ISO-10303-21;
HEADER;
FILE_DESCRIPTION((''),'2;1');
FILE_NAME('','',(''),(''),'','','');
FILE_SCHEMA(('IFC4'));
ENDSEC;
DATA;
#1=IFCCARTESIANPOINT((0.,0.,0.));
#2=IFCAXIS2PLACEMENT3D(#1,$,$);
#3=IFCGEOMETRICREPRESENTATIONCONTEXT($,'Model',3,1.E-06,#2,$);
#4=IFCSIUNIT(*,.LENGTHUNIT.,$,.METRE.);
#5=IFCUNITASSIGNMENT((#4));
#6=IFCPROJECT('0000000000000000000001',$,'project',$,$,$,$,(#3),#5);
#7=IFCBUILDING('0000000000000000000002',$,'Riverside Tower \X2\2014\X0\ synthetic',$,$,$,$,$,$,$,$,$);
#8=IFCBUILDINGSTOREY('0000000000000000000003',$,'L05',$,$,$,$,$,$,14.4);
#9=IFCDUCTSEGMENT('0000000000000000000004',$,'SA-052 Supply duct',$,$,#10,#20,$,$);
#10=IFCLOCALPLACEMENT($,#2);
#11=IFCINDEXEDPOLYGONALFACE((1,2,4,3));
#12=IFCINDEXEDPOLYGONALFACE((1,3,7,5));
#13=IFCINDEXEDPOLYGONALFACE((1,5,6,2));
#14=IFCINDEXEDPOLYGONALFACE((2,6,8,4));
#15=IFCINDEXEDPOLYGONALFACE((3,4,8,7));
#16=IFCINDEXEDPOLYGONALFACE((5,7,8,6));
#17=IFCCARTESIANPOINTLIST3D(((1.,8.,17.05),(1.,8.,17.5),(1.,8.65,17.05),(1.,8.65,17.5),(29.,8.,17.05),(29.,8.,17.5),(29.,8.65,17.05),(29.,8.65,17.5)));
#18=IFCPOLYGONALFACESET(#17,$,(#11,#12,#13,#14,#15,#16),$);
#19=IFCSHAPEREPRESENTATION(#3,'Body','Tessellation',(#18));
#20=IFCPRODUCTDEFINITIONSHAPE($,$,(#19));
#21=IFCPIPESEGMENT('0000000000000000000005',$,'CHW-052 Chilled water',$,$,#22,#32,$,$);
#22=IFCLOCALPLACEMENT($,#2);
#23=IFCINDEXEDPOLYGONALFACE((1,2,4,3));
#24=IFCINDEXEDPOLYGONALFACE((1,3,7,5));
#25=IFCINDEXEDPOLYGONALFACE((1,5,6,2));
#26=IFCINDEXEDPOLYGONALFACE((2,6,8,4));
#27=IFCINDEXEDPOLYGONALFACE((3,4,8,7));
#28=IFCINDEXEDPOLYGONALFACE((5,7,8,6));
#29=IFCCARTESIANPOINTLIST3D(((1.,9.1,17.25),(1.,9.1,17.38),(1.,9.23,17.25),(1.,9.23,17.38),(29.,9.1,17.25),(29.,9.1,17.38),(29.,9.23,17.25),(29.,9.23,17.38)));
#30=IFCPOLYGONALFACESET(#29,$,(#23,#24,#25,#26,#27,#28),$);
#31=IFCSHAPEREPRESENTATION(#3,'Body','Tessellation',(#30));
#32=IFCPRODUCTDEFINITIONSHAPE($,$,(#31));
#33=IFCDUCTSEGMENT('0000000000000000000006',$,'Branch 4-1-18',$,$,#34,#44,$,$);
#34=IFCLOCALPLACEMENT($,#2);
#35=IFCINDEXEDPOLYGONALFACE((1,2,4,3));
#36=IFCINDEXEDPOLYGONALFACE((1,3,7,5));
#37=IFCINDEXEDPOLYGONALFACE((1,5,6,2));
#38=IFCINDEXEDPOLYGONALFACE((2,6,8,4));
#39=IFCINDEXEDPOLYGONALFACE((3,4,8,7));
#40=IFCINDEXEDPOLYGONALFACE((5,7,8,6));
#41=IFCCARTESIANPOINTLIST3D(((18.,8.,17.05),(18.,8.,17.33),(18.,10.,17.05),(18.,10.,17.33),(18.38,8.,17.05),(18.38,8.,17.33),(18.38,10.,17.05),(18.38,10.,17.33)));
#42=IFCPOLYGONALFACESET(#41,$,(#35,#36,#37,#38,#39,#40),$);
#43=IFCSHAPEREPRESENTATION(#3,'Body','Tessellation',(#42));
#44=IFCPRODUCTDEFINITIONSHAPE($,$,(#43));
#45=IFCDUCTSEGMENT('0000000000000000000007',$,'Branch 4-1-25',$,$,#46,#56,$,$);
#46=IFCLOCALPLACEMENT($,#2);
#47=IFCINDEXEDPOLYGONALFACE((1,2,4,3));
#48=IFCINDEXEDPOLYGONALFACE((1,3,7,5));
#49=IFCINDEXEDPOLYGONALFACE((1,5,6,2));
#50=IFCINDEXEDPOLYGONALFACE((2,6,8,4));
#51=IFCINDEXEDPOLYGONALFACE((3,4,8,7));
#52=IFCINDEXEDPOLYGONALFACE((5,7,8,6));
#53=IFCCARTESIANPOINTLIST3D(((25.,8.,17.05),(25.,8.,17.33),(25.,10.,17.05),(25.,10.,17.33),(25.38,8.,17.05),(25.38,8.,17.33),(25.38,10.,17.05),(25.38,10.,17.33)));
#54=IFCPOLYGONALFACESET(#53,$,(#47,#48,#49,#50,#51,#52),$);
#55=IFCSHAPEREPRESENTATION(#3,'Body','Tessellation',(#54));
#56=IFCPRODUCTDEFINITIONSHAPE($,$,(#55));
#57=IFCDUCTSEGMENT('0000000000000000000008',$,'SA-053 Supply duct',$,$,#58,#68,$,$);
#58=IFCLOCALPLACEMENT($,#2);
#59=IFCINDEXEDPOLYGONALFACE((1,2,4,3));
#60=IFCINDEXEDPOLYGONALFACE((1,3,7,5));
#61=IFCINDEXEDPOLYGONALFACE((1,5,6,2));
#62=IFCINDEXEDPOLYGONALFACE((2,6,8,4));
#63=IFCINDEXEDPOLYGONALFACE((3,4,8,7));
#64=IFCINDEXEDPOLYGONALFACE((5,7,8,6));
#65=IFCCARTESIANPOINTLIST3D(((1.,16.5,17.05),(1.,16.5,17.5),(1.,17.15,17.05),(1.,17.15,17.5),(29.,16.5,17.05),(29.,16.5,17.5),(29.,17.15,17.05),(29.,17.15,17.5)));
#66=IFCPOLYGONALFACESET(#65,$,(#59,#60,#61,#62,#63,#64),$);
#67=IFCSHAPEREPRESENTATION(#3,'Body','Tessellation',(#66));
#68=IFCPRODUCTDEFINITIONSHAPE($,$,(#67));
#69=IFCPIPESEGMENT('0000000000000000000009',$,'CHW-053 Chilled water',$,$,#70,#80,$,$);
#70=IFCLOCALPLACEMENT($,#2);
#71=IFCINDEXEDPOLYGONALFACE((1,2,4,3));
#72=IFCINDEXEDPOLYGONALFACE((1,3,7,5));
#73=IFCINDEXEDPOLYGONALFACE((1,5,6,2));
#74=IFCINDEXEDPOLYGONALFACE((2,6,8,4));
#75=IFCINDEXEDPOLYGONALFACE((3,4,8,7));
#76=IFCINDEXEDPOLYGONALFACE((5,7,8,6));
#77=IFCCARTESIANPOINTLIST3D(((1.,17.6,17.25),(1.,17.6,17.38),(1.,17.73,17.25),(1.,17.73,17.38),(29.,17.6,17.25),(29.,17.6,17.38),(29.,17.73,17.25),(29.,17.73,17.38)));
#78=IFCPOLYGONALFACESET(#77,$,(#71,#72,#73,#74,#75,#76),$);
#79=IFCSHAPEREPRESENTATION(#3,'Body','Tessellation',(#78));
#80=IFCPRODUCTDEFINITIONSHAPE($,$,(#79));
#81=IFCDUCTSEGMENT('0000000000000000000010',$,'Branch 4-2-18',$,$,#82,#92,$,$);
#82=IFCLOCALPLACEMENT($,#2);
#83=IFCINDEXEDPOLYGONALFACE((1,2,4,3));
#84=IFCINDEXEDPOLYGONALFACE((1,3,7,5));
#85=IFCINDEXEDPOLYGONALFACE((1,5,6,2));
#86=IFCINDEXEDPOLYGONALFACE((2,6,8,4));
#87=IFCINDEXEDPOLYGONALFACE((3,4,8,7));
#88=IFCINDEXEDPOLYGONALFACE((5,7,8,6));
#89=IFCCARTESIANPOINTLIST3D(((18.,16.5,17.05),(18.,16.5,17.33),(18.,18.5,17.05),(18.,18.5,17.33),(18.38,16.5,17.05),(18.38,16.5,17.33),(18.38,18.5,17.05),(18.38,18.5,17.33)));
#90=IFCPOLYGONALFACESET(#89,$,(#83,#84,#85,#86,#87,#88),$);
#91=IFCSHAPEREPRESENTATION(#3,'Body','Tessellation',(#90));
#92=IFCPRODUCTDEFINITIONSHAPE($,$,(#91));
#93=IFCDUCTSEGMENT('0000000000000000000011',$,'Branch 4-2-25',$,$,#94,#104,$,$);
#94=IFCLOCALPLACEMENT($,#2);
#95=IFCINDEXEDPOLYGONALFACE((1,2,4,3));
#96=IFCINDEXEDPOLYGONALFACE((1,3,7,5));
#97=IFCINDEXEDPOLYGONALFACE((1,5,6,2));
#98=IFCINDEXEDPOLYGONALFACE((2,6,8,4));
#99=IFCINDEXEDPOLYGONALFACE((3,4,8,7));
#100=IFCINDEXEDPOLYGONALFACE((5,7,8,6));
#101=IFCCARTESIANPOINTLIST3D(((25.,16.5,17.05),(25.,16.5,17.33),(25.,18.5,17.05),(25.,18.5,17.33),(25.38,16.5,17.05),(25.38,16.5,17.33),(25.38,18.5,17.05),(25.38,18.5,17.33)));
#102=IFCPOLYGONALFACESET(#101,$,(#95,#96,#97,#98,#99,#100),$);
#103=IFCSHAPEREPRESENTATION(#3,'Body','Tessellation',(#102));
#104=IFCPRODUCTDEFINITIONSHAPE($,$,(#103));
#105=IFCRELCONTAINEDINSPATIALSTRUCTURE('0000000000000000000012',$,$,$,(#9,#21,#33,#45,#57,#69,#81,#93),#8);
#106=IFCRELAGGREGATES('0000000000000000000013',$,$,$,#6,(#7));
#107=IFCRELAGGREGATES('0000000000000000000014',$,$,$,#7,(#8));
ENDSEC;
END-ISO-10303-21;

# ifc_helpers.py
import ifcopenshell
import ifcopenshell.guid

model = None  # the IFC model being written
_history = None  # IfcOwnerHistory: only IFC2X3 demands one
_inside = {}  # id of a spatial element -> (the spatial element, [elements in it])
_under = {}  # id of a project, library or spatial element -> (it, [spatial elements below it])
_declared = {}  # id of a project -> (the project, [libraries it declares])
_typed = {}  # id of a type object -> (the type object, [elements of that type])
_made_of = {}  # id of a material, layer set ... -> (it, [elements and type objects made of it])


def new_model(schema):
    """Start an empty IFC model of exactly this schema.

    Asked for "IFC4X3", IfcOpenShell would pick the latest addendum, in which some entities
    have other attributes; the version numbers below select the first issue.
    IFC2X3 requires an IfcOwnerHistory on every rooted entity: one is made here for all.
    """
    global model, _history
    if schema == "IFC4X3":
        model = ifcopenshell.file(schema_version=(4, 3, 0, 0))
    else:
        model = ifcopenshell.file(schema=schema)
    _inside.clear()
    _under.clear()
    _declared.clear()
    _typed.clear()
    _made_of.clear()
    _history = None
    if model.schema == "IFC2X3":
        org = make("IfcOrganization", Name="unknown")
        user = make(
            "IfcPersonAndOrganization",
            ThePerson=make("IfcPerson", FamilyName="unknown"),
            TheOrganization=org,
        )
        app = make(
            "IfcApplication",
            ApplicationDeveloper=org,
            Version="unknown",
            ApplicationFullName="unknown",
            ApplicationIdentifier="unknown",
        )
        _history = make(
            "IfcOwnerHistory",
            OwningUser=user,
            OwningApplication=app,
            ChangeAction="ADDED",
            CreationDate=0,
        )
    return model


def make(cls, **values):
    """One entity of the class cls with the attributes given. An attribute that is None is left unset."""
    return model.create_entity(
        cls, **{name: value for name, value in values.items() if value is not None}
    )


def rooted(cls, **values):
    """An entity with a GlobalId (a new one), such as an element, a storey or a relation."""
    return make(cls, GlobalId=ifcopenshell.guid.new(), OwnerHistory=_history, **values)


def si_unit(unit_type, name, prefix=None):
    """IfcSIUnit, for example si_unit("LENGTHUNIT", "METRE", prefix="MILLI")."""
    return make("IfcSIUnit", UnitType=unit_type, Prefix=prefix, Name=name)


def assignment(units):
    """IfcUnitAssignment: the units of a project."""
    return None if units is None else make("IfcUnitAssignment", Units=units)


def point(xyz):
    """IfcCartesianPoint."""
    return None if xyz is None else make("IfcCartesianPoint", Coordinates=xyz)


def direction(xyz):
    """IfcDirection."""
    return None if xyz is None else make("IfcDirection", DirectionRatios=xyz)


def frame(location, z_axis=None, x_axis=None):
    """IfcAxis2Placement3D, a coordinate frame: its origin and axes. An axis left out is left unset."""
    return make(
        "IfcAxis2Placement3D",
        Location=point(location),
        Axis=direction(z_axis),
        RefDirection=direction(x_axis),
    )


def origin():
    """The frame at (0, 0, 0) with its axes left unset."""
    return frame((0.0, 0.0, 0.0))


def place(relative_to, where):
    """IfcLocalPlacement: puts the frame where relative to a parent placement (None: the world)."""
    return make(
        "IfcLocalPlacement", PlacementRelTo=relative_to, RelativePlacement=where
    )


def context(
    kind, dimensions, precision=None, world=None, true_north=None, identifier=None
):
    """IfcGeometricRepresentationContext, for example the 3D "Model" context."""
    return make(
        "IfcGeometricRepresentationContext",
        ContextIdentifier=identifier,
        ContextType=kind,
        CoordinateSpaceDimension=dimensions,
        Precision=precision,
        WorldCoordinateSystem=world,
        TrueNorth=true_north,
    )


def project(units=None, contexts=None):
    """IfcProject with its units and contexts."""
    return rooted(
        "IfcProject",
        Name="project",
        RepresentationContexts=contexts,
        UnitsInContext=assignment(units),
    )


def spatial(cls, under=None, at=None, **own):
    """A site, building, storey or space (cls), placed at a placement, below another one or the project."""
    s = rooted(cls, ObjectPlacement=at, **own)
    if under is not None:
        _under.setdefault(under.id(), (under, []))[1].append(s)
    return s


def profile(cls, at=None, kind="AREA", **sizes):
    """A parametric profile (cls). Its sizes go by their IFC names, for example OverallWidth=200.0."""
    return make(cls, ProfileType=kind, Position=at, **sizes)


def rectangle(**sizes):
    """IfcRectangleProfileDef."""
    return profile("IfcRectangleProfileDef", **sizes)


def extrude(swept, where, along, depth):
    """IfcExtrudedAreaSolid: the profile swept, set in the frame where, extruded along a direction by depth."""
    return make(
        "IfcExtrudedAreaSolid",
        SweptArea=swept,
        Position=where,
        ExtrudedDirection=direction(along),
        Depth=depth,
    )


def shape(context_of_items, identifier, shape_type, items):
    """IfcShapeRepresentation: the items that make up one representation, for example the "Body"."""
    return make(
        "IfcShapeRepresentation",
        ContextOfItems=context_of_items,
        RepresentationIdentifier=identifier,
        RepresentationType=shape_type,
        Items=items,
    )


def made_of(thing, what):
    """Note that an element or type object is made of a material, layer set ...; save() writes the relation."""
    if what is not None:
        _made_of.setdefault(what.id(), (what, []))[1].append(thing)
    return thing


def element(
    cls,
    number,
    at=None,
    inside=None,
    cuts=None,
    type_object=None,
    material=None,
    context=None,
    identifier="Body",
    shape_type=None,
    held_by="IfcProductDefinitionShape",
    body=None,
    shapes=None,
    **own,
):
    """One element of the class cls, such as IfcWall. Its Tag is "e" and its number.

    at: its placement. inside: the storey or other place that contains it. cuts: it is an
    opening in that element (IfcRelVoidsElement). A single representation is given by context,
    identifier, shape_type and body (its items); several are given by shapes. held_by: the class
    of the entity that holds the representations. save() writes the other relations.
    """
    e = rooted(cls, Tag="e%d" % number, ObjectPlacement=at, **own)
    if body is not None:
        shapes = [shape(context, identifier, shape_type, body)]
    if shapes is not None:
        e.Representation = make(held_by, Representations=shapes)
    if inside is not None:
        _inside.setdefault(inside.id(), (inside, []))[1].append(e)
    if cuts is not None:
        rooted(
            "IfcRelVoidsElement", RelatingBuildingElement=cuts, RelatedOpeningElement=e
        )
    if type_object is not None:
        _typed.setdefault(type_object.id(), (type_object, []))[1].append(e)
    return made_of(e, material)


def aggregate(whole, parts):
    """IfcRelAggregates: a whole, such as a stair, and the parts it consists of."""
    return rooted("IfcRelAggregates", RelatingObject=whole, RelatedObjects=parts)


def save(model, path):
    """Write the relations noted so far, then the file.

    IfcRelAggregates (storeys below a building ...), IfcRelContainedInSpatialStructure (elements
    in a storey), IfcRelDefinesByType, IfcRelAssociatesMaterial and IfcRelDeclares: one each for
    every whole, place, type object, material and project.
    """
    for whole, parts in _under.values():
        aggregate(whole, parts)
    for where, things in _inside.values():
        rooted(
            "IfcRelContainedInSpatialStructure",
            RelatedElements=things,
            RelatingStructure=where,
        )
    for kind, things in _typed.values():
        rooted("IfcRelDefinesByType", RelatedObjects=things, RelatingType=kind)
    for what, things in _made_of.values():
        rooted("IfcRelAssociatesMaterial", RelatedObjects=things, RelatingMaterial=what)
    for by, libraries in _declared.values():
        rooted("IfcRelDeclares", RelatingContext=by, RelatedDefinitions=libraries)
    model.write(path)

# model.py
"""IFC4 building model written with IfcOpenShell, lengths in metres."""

from ifc_helpers import new_model, si_unit, frame, origin, place, context, project, spatial, rectangle, extrude, element, save


model = new_model("IFC4")

# Units and contexts
model_context = context("Model", 3, precision=1e-06, world=origin())
ifc_project = project(units=[si_unit("LENGTHUNIT", "METRE")], contexts=[model_context])

# Building, storey
building = spatial("IfcBuilding", under=ifc_project, Name="Riverside Tower — synthetic")
storey = spatial("IfcBuildingStorey", under=building, Name="L05", Elevation=14.4)

# Duct segment
duct_segment_1_placement = place(None, frame((15.0, 8.325, 17.05)))
element("IfcDuctSegment", 1, at=duct_segment_1_placement, inside=storey, Name="SA-052 Supply duct", context=model_context, shape_type="SweptSolid", body=[
    extrude(rectangle(XDim=28.0, YDim=0.65), origin(), (0.0, 0.0, 1.0), 0.45),
])

# Pipe segment
pipe_segment_1_placement = place(None, frame((15.0, 9.165, 17.25)))
element("IfcPipeSegment", 2, at=pipe_segment_1_placement, inside=storey, Name="CHW-052 Chilled water", context=model_context, shape_type="SweptSolid", body=[
    extrude(rectangle(XDim=28.0, YDim=0.13), origin(), (0.0, 0.0, 1.0), 0.13),
])

# Duct segments
for number, where, name in (
    (3, (18.19, 9.0, 17.05), "Branch 4-1-18"),
    (4, (25.19, 9.0, 17.05), "Branch 4-1-25"),
):
    element("IfcDuctSegment", number, at=place(None, frame(where)), inside=storey, Name=name, context=model_context, shape_type="SweptSolid", body=[
        extrude(rectangle(XDim=0.38, YDim=2.0), origin(), (0.0, 0.0, 1.0), 0.28),
    ])
duct_segment_2_placement = place(None, frame((15.0, 16.825, 17.05)))
element("IfcDuctSegment", 5, at=duct_segment_2_placement, inside=storey, Name="SA-053 Supply duct", context=model_context, shape_type="SweptSolid", body=[
    extrude(rectangle(XDim=28.0, YDim=0.65), origin(), (0.0, 0.0, 1.0), 0.45),
])

# Pipe segment
pipe_segment_2_placement = place(None, frame((15.0, 17.665, 17.25)))
element("IfcPipeSegment", 6, at=pipe_segment_2_placement, inside=storey, Name="CHW-053 Chilled water", context=model_context, shape_type="SweptSolid", body=[
    extrude(rectangle(XDim=28.0, YDim=0.13), origin(), (0.0, 0.0, 1.0), 0.13),
])

# Duct segments
for number, where, name in (
    (7, (18.19, 17.5, 17.05), "Branch 4-2-18"),
    (8, (25.19, 17.5, 17.05), "Branch 4-2-25"),
):
    element("IfcDuctSegment", number, at=place(None, frame(where)), inside=storey, Name=name, context=model_context, shape_type="SweptSolid", body=[
        extrude(rectangle(XDim=0.38, YDim=2.0), origin(), (0.0, 0.0, 1.0), 0.28),
    ])

save(model, "model.ifc")
